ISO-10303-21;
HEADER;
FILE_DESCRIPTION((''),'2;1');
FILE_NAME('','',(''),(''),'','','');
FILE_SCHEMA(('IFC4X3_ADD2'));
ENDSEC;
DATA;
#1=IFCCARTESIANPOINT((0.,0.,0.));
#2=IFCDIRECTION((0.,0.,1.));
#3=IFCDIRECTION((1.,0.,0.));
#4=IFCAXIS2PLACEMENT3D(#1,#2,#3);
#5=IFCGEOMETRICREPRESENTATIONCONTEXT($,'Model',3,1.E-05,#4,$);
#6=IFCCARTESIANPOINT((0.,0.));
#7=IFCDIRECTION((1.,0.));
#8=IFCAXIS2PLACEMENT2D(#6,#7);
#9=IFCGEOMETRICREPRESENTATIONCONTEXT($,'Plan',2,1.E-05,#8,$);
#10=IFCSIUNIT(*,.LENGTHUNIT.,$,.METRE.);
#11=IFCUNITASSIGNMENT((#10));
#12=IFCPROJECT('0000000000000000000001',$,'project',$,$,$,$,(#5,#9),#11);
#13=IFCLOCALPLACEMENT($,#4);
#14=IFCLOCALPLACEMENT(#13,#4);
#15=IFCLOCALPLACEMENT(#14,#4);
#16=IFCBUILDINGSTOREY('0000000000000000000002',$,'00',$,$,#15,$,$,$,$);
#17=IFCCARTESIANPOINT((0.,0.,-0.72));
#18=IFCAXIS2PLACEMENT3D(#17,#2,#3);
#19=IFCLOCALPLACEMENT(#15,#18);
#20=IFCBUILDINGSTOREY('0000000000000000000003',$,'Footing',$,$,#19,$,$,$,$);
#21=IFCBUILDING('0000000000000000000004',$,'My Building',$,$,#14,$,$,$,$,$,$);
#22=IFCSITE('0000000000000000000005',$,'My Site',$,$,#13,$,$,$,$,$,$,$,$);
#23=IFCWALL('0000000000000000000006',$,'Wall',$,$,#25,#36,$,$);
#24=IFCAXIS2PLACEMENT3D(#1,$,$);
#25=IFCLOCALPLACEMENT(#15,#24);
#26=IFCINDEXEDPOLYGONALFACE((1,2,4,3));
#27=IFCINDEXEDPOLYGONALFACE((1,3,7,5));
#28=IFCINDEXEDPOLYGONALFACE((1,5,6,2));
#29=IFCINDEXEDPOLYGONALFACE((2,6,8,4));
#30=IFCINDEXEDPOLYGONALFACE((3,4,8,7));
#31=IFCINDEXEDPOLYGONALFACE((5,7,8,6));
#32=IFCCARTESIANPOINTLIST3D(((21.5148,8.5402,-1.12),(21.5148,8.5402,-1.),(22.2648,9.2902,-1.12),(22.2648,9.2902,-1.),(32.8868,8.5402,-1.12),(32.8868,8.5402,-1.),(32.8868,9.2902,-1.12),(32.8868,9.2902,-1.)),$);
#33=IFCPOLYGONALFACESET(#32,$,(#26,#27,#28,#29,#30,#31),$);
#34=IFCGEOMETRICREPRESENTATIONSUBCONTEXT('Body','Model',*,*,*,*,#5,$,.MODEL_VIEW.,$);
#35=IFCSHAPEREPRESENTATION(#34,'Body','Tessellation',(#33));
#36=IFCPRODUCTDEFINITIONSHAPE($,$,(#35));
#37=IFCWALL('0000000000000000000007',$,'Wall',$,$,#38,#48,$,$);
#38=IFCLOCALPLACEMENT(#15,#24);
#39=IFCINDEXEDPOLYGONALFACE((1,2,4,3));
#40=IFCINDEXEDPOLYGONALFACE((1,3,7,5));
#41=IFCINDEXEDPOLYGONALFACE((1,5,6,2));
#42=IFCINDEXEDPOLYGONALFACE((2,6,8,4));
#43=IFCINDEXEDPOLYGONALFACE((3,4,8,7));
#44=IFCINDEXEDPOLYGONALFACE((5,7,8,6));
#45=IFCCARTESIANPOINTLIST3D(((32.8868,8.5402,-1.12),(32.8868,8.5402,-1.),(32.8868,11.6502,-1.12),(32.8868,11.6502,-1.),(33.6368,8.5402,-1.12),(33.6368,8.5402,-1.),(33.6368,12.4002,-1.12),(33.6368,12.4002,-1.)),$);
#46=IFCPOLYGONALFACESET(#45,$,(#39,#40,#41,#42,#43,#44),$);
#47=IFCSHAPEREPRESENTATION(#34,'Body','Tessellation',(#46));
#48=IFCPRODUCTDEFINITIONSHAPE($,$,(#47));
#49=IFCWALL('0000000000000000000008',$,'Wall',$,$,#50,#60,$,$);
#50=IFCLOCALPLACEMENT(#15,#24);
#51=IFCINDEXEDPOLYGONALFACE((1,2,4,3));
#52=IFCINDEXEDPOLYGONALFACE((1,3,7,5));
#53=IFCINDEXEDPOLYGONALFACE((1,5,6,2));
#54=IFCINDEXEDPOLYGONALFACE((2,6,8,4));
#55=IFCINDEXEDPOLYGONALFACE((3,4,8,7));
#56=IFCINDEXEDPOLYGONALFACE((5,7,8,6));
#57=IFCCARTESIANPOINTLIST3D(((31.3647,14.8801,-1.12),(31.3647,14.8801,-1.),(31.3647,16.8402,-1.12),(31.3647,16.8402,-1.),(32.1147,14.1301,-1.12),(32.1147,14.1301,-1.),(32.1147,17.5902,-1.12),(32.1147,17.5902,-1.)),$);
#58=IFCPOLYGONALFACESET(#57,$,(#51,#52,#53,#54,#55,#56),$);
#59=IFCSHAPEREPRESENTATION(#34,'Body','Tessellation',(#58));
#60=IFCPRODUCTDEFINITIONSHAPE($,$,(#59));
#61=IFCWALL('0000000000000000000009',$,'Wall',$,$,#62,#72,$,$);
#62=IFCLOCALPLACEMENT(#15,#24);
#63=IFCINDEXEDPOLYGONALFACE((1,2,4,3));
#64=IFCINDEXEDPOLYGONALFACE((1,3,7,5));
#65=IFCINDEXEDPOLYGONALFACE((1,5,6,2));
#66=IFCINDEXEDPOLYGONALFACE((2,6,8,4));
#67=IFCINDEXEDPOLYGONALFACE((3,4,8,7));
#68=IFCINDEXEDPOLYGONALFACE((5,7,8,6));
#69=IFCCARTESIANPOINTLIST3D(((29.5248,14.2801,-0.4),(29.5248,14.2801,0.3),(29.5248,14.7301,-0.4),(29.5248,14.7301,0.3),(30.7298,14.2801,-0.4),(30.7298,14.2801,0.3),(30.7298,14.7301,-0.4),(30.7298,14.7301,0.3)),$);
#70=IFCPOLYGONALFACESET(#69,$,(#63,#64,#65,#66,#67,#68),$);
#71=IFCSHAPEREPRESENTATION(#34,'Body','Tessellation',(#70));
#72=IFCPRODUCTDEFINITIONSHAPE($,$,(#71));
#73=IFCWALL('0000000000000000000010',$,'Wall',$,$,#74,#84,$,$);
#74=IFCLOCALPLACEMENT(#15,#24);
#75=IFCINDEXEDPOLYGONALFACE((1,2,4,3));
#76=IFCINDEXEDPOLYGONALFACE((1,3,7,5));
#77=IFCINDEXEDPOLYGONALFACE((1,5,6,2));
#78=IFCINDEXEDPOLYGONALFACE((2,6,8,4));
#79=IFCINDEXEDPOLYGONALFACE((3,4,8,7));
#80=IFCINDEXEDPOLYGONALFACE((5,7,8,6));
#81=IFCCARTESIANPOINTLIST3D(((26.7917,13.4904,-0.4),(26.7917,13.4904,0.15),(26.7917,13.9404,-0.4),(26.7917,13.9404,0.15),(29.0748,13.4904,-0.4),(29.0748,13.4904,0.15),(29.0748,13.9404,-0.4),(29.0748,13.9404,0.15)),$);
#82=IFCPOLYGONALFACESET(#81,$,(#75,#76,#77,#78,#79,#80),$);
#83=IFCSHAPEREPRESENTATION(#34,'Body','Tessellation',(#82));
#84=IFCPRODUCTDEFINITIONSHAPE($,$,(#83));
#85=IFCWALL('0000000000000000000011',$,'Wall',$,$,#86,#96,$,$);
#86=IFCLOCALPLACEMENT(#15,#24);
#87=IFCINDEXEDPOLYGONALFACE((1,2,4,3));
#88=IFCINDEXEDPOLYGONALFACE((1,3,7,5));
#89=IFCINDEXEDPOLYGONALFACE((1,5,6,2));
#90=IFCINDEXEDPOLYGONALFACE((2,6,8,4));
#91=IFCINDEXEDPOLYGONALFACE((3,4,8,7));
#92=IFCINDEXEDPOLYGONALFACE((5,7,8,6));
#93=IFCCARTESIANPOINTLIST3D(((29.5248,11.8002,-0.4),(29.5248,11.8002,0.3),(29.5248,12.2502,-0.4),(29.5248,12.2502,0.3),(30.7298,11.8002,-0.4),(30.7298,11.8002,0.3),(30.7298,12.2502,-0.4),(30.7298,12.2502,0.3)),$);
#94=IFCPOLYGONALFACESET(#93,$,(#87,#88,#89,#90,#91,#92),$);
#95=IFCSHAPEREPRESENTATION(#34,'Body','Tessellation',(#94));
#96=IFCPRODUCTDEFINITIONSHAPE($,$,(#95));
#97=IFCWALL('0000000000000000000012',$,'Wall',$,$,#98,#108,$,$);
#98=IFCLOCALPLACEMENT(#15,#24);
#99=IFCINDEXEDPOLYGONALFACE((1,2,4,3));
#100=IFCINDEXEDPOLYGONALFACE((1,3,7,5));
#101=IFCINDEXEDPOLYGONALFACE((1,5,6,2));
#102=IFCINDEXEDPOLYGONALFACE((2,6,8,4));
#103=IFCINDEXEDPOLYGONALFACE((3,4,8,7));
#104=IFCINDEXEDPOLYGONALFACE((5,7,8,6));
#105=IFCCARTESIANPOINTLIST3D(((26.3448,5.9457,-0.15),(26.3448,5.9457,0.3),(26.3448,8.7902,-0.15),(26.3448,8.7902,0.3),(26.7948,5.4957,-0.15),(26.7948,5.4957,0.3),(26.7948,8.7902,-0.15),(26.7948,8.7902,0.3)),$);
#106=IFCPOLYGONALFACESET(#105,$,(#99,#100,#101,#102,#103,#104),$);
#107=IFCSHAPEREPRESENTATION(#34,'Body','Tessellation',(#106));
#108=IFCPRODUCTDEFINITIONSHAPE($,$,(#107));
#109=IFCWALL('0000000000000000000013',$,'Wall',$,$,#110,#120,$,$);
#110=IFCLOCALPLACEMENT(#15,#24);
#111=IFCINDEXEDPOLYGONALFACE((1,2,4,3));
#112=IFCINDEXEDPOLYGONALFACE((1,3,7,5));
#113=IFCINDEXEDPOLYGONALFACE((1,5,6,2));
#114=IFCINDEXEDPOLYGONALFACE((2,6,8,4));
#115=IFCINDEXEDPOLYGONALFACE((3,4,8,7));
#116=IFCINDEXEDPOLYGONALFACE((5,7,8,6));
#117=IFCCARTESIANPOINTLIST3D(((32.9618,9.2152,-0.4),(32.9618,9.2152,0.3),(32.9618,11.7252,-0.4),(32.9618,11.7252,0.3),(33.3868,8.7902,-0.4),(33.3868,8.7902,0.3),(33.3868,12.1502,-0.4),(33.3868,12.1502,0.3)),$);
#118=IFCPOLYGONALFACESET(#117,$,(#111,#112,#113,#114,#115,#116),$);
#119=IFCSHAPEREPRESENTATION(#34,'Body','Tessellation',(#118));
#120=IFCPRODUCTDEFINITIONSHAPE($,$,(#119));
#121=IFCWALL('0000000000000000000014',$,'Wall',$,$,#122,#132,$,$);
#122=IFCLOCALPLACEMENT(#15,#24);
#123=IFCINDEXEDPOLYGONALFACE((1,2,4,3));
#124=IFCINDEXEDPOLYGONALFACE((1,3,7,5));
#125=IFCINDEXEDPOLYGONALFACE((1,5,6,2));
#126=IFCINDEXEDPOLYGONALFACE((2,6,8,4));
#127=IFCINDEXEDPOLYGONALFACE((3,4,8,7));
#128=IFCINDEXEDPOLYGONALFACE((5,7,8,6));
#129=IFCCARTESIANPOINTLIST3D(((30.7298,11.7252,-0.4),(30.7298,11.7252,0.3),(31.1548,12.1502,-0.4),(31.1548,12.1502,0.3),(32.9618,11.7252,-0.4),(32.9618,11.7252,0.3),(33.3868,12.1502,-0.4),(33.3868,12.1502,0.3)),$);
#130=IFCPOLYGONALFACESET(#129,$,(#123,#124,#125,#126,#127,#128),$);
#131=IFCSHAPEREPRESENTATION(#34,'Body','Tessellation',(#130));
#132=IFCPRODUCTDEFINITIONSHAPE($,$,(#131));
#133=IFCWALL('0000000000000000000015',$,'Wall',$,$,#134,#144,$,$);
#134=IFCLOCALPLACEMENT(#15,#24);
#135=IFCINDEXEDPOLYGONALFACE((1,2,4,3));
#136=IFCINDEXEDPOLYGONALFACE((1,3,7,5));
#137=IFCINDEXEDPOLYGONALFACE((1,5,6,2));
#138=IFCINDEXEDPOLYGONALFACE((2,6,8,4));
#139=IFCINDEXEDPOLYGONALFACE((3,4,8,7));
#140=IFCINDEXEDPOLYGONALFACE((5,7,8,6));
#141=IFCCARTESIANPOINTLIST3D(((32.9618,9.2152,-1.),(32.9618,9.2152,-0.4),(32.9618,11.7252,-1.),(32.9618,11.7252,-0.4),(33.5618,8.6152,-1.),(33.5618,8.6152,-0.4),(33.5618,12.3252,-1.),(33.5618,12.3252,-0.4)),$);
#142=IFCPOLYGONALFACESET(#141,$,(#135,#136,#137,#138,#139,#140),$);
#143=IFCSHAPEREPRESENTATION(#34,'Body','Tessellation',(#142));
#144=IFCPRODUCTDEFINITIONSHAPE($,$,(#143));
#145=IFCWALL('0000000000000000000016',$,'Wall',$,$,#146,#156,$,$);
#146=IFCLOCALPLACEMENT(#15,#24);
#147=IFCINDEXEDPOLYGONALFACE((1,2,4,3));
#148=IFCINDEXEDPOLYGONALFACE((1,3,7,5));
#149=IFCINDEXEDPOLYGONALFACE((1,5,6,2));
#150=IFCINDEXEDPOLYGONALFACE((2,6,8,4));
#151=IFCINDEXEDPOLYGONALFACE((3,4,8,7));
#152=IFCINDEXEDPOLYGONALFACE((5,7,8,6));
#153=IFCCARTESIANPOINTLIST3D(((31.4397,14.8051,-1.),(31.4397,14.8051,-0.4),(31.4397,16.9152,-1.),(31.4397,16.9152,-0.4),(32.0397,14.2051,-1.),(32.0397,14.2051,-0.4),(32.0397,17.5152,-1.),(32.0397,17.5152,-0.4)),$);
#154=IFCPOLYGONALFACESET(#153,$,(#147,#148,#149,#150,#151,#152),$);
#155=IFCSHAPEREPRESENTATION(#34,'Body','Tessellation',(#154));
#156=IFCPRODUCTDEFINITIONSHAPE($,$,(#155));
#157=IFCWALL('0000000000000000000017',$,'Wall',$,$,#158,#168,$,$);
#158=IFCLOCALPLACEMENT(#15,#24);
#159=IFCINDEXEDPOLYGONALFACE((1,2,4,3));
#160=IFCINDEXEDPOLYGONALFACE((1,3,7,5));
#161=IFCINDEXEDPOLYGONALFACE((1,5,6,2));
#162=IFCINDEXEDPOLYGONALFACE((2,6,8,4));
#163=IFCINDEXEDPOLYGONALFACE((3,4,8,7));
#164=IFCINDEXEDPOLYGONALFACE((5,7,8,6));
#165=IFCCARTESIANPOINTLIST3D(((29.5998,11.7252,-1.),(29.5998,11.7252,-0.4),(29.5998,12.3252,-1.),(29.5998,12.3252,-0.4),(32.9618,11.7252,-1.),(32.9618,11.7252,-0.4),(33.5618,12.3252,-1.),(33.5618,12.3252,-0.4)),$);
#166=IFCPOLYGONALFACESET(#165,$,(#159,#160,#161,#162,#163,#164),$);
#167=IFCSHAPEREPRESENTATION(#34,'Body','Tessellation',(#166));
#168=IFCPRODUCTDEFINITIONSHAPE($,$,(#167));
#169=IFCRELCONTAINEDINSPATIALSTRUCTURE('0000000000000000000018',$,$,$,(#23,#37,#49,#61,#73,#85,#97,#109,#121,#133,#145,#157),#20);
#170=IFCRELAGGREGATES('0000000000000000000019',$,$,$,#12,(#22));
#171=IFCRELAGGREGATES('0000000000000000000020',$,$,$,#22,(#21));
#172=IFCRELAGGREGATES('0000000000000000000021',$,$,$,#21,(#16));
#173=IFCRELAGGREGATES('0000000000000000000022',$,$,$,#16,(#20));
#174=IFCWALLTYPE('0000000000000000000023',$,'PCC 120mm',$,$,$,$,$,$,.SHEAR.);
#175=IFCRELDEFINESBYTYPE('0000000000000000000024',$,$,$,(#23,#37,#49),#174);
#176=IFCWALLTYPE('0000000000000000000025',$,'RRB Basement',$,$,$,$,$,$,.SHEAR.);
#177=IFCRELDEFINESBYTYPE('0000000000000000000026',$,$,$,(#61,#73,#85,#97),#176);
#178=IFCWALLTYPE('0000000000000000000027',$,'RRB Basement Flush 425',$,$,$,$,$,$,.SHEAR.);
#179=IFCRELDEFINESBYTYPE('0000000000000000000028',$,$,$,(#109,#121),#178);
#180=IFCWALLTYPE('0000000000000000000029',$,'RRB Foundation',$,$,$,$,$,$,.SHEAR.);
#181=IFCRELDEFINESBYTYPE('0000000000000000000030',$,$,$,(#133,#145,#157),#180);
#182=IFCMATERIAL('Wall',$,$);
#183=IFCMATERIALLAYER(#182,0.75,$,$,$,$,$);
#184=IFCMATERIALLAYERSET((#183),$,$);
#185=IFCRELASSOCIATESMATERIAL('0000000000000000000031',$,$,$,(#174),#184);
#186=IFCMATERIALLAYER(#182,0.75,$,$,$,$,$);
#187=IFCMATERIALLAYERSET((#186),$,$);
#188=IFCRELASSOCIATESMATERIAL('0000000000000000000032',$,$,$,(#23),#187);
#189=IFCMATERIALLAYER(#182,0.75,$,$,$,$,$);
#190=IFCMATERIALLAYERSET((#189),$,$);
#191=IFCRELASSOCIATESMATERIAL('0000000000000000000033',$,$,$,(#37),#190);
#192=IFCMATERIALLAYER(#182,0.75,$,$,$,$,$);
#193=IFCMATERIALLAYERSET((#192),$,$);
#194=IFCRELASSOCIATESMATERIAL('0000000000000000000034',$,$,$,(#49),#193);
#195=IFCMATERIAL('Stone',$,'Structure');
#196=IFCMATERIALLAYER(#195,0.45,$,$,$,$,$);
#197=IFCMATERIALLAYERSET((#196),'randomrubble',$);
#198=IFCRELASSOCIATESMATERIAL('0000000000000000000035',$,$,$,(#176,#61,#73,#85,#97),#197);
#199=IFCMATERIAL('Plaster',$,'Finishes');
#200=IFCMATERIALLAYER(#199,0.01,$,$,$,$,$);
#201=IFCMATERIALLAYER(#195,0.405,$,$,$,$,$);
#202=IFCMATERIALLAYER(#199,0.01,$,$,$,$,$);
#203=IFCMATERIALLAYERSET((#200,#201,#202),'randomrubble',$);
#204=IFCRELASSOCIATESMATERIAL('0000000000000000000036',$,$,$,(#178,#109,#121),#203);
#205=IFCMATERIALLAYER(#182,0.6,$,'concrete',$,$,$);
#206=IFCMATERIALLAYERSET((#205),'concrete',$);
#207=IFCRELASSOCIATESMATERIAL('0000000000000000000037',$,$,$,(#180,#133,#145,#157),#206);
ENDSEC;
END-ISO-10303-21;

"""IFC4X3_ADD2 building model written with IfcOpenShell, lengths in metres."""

from ifc_helpers import new_model, si_unit, frame, origin_with_axes, origin_2d_with_axis, place, context, subcontext, project, spatial, line, indexed_curve, outline, extrude, material, layer, layer_set, layer_usage, type_object, element, save


model = new_model("IFC4X3_ADD2")

# Units and contexts
model_context = context("Model", 3, precision=1e-05, world=origin_with_axes())
plan_context = context("Plan", 2, precision=1e-05, world=origin_2d_with_axis())
body_context = subcontext(model_context, "Body", "Model", "MODEL_VIEW")
ifc_project = project(units=[si_unit("LENGTHUNIT", "METRE")], contexts=[model_context, plan_context])

# Site, building, storeys
site_placement = place(None, origin_with_axes())
site = spatial("IfcSite", under=ifc_project, at=site_placement, Name="My Site")
building_placement = place(site_placement, origin_with_axes())
building = spatial("IfcBuilding", under=site, at=building_placement, Name="My Building")
storey_1_placement = place(building_placement, origin_with_axes())
storey_1 = spatial("IfcBuildingStorey", under=building, at=storey_1_placement, Name="00")
storey_2_placement = place(storey_1_placement, frame((0.0, 0.0, -0.72), z_axis=(0.0, 0.0, 1.0), x_axis=(1.0, 0.0, 0.0)))
storey_2 = spatial("IfcBuildingStorey", under=storey_1, at=storey_2_placement, Name="Footing")

# Shared definitions
ifc_material_1 = material(Name="Wall")
ifc_material_2 = material(Name="Plaster", Category="Finishes")
ifc_material_3 = material(Name="Stone", Category="Structure")

# Walls
ifc_layer_1 = layer(ifc_material_1, 0.75)
ifc_layer_set_1 = layer_set([ifc_layer_1])
wall_type_1 = type_object("IfcWallType", Name="PCC 120mm", PredefinedType="SHEAR", material=ifc_layer_set_1)
ifc_layer_2 = layer(ifc_material_1, 0.75)
ifc_layer_set_2 = layer_set([ifc_layer_2])
ifc_layer_usage_1 = layer_usage(ifc_layer_set_2, "AXIS2", "POSITIVE", 0.0)
wall_1_placement = place(storey_2_placement, frame((22.2648, 8.5402, -0.4), z_axis=(0.0, 0.0, 1.0), x_axis=(1.0, 0.0, 0.0)))
element("IfcWall", 1, at=wall_1_placement, inside=storey_2, type_object=wall_type_1, material=ifc_layer_usage_1, Name="Wall", context=body_context, shape_type="SweptSolid", body=[
    extrude(outline(indexed_curve([(-0.75, 0.0), (0.0, 0.75), (10.622, 0.75), (10.622, 0.0)], segments=[line(1, 2, 3, 4, 1)])), origin_with_axes(), (0.0, 0.0, 1.0), 0.12),
])
ifc_layer_3 = layer(ifc_material_1, 0.75)
ifc_layer_set_3 = layer_set([ifc_layer_3])
ifc_layer_usage_2 = layer_usage(ifc_layer_set_3, "AXIS2", "NEGATIVE", 0.0)
wall_2_placement = place(storey_2_placement, frame((32.8868, 8.5402, -0.4), z_axis=(0.0, 0.0, 1.0), x_axis=(0.0, 1.0, 0.0)))
element("IfcWall", 2, at=wall_2_placement, inside=storey_2, type_object=wall_type_1, material=ifc_layer_usage_2, Name="Wall", context=body_context, shape_type="SweptSolid", body=[
    extrude(outline(indexed_curve([(0.0, -0.75), (0.0, 0.0), (3.11, 0.0), (3.86, -0.75)], segments=[line(1, 2, 3, 4, 1)])), origin_with_axes(), (0.0, 0.0, 1.0), 0.12),
])
ifc_layer_4 = layer(ifc_material_1, 0.75)
ifc_layer_set_4 = layer_set([ifc_layer_4])
ifc_layer_usage_3 = layer_usage(ifc_layer_set_4, "AXIS2", "NEGATIVE", 0.0)
wall_3_placement = place(storey_2_placement, frame((31.3647, 14.1301, -0.4), z_axis=(0.0, 0.0, 1.0), x_axis=(0.0, 1.0, 0.0)))
element("IfcWall", 3, at=wall_3_placement, inside=storey_2, type_object=wall_type_1, material=ifc_layer_usage_3, Name="Wall", context=body_context, shape_type="SweptSolid", body=[
    extrude(outline(indexed_curve([(0.0, -0.75), (0.75, 0.0), (2.71, 0.0), (3.46, -0.75)], segments=[line(1, 2, 3, 4, 1)])), origin_with_axes(), (0.0, 0.0, 1.0), 0.12),
])
ifc_layer_5 = layer(ifc_material_3, 0.45)
ifc_layer_set_5 = layer_set([ifc_layer_5], Name="randomrubble")
ifc_layer_usage_4 = layer_usage(ifc_layer_set_5, "AXIS2", "POSITIVE", 0.0)
wall_type_2 = type_object("IfcWallType", Name="RRB Basement", PredefinedType="SHEAR", material=ifc_layer_set_5)
wall_4_placement = place(storey_2_placement, frame((29.5248, 14.2801, 0.32), z_axis=(0.0, 0.0, 1.0), x_axis=(1.0, 0.0, 0.0)))
element("IfcWall", 4, at=wall_4_placement, inside=storey_2, type_object=wall_type_2, material=ifc_layer_usage_4, Name="Wall", context=body_context, shape_type="SweptSolid", body=[
    extrude(outline(indexed_curve([(0.0, 0.0), (0.0, 0.45), (1.205, 0.45), (1.205, 0.0)], segments=[line(1, 2, 3, 4, 1)])), origin_with_axes(), (0.0, 0.0, 1.0), 0.7),
])
ifc_layer_usage_5 = layer_usage(ifc_layer_set_5, "AXIS2", "POSITIVE", 0.0)
wall_5_placement = place(storey_2_placement, frame((26.7917, 13.4904, 0.32), z_axis=(0.0, 0.0, 1.0), x_axis=(1.0, 0.0, 0.0)))
element("IfcWall", 5, at=wall_5_placement, inside=storey_2, type_object=wall_type_2, material=ifc_layer_usage_5, Name="Wall", context=body_context, shape_type="SweptSolid", body=[
    extrude(outline(indexed_curve([(0.0, 0.0), (0.0, 0.45), (2.2831, 0.45), (2.2831, 0.0)], segments=[line(1, 2, 3, 4, 1)])), origin_with_axes(), (0.0, 0.0, 1.0), 0.55),
])
ifc_layer_usage_6 = layer_usage(ifc_layer_set_5, "AXIS2", "POSITIVE", 0.0)
wall_6_placement = place(storey_2_placement, frame((29.5248, 11.8002, 0.32), z_axis=(0.0, 0.0, 1.0), x_axis=(1.0, 0.0, 0.0)))
element("IfcWall", 6, at=wall_6_placement, inside=storey_2, type_object=wall_type_2, material=ifc_layer_usage_6, Name="Wall", context=body_context, shape_type="SweptSolid", body=[
    extrude(outline(indexed_curve([(0.0, 0.0), (0.0, 0.45), (1.205, 0.45), (1.205, 0.0)], segments=[line(1, 2, 3, 4, 1)])), origin_with_axes(), (0.0, 0.0, 1.0), 0.7),
])
ifc_layer_usage_7 = layer_usage(ifc_layer_set_5, "AXIS2", "POSITIVE", 0.0)
wall_7_placement = place(storey_2_placement, frame((26.7948, 5.4957, 0.57), z_axis=(0.0, 0.0, 1.0), x_axis=(0.000001, 1.0, 0.0)))
element("IfcWall", 7, at=wall_7_placement, inside=storey_2, type_object=wall_type_2, material=ifc_layer_usage_7, Name="Wall", context=body_context, shape_type="SweptSolid", body=[
    extrude(outline(indexed_curve([(0.0, 0.0), (0.45, 0.45), (3.2945, 0.45), (3.2945, 0.0)], segments=[line(1, 2, 3, 4, 1)])), origin_with_axes(), (0.0, 0.0, 1.0), 0.45),
])
ifc_layer_6 = layer(ifc_material_2, 0.01)
ifc_layer_7 = layer(ifc_material_3, 0.405)
ifc_layer_8 = layer(ifc_material_2, 0.01)
ifc_layer_set_6 = layer_set([ifc_layer_6, ifc_layer_7, ifc_layer_8], Name="randomrubble")
ifc_layer_usage_8 = layer_usage(ifc_layer_set_6, "AXIS2", "POSITIVE", 0.0)
wall_type_3 = type_object("IfcWallType", Name="RRB Basement Flush 425", PredefinedType="SHEAR", material=ifc_layer_set_6)
wall_8_placement = place(storey_2_placement, frame((33.3868, 8.7902, 0.32), z_axis=(0.0, 0.0, 1.0), x_axis=(0.0, 1.0, 0.0)))
element("IfcWall", 8, at=wall_8_placement, inside=storey_2, type_object=wall_type_3, material=ifc_layer_usage_8, Name="Wall", context=body_context, shape_type="SweptSolid", body=[
    extrude(outline(indexed_curve([(0.0, 0.0), (0.425, 0.425), (2.935, 0.425), (3.36, 0.0)], segments=[line(1, 2, 3, 4, 1)])), origin_with_axes(), (0.0, 0.0, 1.0), 0.7),
])
ifc_layer_usage_9 = layer_usage(ifc_layer_set_6, "AXIS2", "POSITIVE", 0.0)
wall_9_placement = place(storey_2_placement, frame((31.1548, 11.7252, 0.32), z_axis=(0.0, 0.0, 1.0), x_axis=(1.0, 0.0, 0.0)))
element("IfcWall", 9, at=wall_9_placement, inside=storey_2, type_object=wall_type_3, material=ifc_layer_usage_9, Name="Wall", context=body_context, shape_type="SweptSolid", body=[
    extrude(outline(indexed_curve([(-0.425, 0.0), (0.0, 0.425), (2.232, 0.425), (1.807, 0.0)], segments=[line(1, 2, 3, 4, 1)])), origin_with_axes(), (0.0, 0.0, 1.0), 0.7),
])
ifc_layer_9 = layer(ifc_material_1, 0.6, Name="concrete")
ifc_layer_set_7 = layer_set([ifc_layer_9], Name="concrete")
wall_type_4 = type_object("IfcWallType", Name="RRB Foundation", PredefinedType="SHEAR", material=ifc_layer_set_7)
ifc_layer_usage_10 = layer_usage(ifc_layer_set_7, "AXIS2", "POSITIVE", 0.0)
wall_10_placement = place(storey_2_placement, frame((33.5618, 8.6152, -0.28), z_axis=(0.0, 0.0, 1.0), x_axis=(0.0, 1.0, 0.0)))
element("IfcWall", 10, at=wall_10_placement, inside=storey_2, type_object=wall_type_4, material=ifc_layer_usage_10, Name="Wall", context=body_context, shape_type="SweptSolid", body=[
    extrude(outline(indexed_curve([(0.0, 0.0), (0.6, 0.6), (3.11, 0.6), (3.71, 0.0)], segments=[line(1, 2, 3, 4, 1)])), origin_with_axes(), (0.0, 0.0, 1.0), 0.6),
])
ifc_layer_usage_11 = layer_usage(ifc_layer_set_7, "AXIS2", "POSITIVE", 0.0)
wall_11_placement = place(storey_2_placement, frame((32.0397, 14.2051, -0.28), z_axis=(0.0, 0.0, 1.0), x_axis=(0.0, 1.0, 0.0)))
element("IfcWall", 11, at=wall_11_placement, inside=storey_2, type_object=wall_type_4, material=ifc_layer_usage_11, Name="Wall", context=body_context, shape_type="SweptSolid", body=[
    extrude(outline(indexed_curve([(0.0, 0.0), (0.6, 0.6), (2.71, 0.6), (3.31, 0.0)], segments=[line(1, 2, 3, 4, 1)])), origin_with_axes(), (0.0, 0.0, 1.0), 0.6),
])
ifc_layer_usage_12 = layer_usage(ifc_layer_set_7, "AXIS2", "POSITIVE", 0.0)
wall_12_placement = place(storey_2_placement, frame((29.5998, 11.7252, -0.28), z_axis=(0.0, 0.0, 1.0), x_axis=(1.0, 0.0, 0.0)))
element("IfcWall", 12, at=wall_12_placement, inside=storey_2, type_object=wall_type_4, material=ifc_layer_usage_12, Name="Wall", context=body_context, shape_type="SweptSolid", body=[
    extrude(outline(indexed_curve([(0.0, 0.0), (0.0, 0.6), (3.962, 0.6), (3.362, 0.0)], segments=[line(1, 2, 3, 4, 1)])), origin_with_axes(), (0.0, 0.0, 1.0), 0.6),
])

save(model, "model.ifc")
